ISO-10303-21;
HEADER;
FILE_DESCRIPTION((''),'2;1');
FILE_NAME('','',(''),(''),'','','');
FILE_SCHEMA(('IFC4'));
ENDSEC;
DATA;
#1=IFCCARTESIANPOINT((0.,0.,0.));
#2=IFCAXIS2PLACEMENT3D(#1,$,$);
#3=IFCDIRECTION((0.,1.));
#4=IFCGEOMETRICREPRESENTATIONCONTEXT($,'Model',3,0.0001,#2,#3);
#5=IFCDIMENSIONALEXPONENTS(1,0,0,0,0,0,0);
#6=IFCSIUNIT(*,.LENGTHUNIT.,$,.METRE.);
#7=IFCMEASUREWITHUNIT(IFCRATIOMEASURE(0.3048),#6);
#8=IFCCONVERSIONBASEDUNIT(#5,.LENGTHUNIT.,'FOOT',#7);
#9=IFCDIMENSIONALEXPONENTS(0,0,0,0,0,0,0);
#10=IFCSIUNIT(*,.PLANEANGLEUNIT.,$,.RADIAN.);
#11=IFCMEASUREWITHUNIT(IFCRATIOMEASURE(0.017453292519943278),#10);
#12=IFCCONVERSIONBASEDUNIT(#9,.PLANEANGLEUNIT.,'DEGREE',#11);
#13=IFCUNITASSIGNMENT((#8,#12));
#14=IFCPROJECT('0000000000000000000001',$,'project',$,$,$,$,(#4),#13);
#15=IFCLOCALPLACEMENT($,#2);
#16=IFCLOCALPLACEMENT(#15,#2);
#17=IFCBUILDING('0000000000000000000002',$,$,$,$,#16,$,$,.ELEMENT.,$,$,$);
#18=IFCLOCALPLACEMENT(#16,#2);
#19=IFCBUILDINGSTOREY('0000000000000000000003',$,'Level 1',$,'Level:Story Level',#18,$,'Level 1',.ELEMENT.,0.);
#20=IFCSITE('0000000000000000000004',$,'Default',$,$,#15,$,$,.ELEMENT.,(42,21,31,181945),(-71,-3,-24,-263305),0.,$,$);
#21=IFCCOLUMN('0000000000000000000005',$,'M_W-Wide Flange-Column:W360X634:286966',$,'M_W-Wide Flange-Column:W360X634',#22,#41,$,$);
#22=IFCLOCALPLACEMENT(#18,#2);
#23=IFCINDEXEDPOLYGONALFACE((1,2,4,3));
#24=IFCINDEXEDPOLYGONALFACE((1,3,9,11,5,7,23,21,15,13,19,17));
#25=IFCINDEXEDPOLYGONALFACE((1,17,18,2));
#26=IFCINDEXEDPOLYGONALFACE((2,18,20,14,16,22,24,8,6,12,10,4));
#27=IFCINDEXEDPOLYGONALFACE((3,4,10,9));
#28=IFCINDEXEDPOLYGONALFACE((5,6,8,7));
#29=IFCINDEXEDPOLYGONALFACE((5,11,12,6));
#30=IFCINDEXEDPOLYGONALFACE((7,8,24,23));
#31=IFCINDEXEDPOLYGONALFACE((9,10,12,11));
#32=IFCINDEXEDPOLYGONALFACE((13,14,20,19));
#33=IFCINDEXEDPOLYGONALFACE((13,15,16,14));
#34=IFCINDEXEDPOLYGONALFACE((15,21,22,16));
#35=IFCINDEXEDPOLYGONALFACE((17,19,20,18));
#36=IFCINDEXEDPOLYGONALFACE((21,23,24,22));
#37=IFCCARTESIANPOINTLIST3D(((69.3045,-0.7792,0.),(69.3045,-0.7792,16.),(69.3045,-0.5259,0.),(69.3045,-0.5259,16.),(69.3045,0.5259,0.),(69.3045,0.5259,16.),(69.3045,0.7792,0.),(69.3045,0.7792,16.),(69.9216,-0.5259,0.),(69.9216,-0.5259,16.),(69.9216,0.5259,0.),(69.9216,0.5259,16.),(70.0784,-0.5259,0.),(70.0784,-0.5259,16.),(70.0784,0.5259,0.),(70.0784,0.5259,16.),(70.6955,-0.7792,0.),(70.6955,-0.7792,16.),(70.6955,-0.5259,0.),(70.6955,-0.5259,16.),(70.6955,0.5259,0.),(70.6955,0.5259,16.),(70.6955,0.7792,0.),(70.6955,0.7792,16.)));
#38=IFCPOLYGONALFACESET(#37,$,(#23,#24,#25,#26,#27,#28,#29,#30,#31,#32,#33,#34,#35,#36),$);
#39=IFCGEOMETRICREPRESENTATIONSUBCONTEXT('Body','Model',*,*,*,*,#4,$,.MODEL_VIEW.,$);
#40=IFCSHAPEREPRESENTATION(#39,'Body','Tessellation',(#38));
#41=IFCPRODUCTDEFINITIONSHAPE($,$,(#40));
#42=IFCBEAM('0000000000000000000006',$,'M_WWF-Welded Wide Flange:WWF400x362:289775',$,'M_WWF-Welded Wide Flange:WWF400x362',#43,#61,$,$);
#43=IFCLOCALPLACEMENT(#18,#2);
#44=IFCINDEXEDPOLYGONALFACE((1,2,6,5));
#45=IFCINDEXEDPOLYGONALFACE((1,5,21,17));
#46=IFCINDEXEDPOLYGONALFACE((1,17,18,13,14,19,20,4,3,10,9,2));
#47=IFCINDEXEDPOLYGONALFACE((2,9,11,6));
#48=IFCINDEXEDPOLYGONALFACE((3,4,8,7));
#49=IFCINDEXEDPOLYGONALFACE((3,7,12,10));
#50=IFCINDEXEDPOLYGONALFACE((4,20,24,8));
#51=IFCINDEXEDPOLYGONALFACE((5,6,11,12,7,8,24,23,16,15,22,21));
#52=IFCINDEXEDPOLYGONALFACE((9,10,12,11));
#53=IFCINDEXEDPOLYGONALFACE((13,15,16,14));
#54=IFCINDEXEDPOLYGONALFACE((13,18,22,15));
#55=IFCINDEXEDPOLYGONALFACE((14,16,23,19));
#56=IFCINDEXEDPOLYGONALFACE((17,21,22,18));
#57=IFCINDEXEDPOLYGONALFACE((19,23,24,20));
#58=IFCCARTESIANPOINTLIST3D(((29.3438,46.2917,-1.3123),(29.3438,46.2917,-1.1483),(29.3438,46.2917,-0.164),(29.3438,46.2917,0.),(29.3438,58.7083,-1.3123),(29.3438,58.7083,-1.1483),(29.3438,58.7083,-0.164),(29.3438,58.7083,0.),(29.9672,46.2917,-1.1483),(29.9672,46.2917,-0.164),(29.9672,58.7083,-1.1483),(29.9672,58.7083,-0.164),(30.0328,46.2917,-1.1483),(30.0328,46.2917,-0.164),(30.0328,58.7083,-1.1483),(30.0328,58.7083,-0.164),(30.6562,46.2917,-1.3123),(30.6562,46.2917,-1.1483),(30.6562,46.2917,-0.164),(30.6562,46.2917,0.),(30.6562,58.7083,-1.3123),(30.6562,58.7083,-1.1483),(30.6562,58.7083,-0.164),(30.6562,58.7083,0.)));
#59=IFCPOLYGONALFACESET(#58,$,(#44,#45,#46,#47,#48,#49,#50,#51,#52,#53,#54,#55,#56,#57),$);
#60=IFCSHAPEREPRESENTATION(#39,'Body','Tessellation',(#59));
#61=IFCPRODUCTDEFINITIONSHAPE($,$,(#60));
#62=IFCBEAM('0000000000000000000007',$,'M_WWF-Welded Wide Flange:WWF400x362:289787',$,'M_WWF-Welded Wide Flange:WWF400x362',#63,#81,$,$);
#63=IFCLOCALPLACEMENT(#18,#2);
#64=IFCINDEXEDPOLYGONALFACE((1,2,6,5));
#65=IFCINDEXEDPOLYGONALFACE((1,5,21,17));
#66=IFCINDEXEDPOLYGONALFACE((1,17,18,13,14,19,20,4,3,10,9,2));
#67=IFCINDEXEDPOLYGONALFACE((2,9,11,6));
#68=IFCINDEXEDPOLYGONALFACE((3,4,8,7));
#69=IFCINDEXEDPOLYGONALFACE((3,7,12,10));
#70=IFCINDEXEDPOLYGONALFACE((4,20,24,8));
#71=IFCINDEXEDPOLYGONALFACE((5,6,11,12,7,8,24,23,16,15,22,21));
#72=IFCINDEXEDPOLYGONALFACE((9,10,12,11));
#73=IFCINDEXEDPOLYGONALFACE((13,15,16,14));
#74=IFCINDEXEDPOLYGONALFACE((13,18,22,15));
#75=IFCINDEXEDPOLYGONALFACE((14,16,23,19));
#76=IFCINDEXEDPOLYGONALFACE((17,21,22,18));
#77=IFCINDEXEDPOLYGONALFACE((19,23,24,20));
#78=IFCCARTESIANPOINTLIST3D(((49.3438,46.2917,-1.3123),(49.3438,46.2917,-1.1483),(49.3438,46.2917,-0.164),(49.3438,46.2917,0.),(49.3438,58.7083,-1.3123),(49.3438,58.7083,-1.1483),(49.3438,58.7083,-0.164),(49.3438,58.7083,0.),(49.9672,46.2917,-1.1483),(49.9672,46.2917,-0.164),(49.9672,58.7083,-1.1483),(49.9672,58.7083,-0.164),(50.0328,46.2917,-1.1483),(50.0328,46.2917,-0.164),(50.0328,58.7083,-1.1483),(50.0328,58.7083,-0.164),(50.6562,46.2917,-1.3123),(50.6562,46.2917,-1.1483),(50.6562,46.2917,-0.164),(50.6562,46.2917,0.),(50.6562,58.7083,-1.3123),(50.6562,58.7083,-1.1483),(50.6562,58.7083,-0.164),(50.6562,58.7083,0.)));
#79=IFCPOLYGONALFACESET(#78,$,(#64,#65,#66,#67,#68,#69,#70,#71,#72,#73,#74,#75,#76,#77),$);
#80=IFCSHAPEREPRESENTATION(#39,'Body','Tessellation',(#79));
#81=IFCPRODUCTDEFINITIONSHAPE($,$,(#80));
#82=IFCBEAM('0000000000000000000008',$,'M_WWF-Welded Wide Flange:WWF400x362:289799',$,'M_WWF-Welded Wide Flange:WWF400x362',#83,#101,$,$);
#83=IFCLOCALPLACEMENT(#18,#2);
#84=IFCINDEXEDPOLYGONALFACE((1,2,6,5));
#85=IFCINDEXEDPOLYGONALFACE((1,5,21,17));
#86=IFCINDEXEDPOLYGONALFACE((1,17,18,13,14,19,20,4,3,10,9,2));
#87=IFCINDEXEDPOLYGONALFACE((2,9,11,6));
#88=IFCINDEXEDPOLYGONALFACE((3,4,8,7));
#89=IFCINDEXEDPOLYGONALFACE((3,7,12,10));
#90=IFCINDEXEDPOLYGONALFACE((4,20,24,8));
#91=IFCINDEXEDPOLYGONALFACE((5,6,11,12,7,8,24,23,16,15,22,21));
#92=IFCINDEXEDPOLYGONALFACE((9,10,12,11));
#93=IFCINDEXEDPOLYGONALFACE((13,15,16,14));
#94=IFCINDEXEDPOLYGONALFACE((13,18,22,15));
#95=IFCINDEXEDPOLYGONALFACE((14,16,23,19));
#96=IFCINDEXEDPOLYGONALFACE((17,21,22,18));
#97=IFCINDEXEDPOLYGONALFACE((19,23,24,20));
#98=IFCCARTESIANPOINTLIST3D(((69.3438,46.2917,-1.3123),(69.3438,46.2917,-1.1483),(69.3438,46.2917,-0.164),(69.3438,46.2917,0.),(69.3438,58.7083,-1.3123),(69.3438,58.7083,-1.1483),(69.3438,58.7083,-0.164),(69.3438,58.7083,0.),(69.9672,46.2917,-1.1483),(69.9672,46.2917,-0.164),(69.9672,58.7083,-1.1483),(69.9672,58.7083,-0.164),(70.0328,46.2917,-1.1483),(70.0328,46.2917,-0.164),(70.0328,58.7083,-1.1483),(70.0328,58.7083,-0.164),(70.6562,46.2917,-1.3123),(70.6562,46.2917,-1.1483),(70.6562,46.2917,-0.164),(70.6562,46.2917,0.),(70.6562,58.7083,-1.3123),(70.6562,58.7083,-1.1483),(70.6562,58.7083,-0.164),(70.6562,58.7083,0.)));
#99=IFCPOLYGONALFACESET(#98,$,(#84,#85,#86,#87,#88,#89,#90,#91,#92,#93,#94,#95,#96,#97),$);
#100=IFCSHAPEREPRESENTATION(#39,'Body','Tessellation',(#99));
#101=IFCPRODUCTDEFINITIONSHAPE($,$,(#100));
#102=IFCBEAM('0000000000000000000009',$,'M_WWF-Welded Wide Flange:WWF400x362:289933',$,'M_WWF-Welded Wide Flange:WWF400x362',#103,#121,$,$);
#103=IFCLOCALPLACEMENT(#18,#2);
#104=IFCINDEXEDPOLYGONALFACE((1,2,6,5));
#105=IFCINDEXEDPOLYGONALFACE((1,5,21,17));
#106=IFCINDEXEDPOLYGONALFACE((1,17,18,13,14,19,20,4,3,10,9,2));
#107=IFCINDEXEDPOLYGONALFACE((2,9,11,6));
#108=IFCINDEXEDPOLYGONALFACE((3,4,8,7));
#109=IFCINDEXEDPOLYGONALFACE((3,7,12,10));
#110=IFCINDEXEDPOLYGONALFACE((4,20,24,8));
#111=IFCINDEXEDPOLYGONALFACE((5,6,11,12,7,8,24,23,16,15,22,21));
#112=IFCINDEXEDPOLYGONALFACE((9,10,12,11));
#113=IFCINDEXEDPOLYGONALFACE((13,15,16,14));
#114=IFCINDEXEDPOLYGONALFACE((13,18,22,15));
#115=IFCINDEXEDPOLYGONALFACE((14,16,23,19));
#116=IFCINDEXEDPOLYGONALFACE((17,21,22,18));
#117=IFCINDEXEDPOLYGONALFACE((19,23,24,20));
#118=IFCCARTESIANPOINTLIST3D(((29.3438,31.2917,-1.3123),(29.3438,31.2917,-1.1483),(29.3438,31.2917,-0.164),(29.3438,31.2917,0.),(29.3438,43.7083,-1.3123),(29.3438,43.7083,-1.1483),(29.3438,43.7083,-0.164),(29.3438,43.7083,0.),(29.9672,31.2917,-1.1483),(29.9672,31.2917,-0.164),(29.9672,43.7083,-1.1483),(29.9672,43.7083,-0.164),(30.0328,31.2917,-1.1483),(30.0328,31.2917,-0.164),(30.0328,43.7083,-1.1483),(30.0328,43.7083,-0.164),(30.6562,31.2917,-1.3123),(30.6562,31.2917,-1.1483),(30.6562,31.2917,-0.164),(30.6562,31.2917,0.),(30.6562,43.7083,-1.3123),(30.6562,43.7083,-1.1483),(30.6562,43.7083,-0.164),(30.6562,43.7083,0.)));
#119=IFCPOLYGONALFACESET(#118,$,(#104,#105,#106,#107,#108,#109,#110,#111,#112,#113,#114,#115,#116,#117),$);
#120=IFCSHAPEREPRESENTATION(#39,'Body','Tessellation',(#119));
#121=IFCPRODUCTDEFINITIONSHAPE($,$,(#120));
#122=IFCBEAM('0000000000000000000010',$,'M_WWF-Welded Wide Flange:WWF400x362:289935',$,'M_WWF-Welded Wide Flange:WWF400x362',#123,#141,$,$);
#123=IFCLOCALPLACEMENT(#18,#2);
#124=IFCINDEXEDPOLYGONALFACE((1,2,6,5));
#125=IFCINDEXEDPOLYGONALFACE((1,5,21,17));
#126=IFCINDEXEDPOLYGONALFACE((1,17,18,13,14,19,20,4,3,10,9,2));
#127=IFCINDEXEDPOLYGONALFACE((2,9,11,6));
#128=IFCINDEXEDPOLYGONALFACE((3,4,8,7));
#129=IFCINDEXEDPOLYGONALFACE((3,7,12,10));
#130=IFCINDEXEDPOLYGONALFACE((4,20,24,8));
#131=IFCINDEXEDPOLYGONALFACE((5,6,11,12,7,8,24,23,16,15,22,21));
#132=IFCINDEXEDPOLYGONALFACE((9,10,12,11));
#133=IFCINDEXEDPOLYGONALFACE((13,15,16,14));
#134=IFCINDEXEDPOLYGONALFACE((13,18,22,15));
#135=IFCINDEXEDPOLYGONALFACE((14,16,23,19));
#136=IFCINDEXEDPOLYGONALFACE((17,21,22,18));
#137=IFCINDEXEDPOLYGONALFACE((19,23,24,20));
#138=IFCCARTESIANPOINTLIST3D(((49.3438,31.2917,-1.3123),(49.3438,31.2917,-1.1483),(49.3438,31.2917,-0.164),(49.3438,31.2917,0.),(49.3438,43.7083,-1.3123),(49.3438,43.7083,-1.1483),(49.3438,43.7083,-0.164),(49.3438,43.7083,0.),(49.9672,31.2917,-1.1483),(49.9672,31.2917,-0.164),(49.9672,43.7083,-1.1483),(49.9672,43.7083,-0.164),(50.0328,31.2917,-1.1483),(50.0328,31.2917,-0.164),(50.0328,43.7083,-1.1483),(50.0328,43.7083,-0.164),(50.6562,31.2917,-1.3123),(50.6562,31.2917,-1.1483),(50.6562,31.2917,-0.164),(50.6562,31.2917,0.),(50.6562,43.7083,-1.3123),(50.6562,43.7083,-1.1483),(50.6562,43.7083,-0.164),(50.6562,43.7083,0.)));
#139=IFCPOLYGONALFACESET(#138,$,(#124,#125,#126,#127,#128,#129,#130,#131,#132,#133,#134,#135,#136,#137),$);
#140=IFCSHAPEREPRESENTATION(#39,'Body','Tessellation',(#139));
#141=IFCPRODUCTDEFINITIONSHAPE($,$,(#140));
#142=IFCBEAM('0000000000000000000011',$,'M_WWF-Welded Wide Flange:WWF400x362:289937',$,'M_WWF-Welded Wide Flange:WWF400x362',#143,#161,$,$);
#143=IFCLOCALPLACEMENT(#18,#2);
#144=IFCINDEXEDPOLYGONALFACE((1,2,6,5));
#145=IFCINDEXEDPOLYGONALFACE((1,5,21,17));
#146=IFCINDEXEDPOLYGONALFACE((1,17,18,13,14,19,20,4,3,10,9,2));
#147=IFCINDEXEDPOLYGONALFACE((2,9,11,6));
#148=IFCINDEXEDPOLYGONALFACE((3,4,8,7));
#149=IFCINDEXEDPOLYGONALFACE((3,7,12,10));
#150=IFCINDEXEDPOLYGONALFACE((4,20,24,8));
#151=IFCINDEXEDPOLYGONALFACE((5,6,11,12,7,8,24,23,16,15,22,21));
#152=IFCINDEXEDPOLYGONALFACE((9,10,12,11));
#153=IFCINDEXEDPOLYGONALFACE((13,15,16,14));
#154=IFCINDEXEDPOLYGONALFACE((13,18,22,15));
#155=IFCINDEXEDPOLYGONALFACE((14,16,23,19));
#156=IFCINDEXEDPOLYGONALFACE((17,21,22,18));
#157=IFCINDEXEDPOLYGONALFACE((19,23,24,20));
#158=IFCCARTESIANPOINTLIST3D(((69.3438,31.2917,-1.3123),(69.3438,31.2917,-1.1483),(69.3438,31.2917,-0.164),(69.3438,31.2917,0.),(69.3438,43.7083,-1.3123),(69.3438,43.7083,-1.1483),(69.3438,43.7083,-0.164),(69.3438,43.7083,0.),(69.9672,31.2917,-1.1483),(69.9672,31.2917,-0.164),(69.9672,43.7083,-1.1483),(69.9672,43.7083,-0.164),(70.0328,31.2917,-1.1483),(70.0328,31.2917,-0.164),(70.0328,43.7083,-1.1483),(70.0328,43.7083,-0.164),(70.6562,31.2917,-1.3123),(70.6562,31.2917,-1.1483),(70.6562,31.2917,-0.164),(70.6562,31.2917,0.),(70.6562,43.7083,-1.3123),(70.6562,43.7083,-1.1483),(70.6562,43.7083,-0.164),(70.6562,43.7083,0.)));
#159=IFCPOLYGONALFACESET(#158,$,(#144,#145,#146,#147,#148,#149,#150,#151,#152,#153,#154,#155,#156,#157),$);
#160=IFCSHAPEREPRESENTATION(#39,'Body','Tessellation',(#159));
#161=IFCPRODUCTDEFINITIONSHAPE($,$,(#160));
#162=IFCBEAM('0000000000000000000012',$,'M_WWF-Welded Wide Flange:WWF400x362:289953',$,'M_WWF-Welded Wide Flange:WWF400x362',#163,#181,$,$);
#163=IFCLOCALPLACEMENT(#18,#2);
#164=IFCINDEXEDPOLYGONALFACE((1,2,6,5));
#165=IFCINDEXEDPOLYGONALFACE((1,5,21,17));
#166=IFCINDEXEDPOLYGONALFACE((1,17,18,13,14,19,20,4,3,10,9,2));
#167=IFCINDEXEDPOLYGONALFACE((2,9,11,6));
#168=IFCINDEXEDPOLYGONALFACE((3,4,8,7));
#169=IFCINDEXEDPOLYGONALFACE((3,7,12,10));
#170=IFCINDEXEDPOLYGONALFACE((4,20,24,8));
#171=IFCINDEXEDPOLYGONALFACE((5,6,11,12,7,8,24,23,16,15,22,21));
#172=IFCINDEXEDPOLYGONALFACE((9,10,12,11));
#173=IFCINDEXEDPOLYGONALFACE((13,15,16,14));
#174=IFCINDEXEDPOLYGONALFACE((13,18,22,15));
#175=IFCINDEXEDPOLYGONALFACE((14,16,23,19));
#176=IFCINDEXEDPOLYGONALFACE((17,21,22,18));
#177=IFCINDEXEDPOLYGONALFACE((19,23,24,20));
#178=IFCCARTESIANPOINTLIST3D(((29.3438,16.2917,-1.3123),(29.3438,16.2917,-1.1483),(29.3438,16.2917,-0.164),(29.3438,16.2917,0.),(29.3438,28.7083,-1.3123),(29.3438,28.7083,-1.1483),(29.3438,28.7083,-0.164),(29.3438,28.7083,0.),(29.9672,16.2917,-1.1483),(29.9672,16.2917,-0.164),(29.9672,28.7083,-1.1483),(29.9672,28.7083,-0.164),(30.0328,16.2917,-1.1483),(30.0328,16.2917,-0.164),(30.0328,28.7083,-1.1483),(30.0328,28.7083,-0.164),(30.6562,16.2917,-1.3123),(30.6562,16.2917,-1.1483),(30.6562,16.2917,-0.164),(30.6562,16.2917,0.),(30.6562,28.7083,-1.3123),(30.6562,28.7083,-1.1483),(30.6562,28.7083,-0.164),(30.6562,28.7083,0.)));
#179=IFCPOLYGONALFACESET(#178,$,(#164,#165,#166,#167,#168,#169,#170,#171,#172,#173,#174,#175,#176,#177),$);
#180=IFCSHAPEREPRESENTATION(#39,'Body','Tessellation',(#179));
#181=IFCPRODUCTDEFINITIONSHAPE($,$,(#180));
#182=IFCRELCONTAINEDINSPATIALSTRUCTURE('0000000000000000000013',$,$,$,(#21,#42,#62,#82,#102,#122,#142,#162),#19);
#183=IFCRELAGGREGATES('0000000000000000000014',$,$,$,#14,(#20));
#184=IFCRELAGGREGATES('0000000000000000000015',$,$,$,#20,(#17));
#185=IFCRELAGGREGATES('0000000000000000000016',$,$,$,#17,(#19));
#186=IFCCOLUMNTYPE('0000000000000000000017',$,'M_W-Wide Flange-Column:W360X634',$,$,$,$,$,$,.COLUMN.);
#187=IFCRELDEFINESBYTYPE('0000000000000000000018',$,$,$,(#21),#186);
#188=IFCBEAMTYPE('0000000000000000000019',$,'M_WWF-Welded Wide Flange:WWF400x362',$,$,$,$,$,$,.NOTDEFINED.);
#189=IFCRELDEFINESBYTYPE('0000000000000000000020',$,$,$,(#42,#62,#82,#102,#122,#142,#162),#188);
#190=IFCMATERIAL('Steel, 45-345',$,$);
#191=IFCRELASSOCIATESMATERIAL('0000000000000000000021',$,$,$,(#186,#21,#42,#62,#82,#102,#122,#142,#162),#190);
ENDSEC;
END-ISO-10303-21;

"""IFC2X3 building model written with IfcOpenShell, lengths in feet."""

from ifc_helpers import new_model, entity, si_unit, converted_unit, direction, frame, frame_2d, origin, place, context, subcontext, project, spatial, polyline, i_section, outline, extrude, source, transform, mapped, material, type_object, type_shapes, element, save


model = new_model("IFC2X3")

# Units and contexts
model_context = context("Model", 3, precision=0.0001, world=origin(), true_north=direction((0.0, 1.0)))
body_context = subcontext(model_context, "Body", "Model", "MODEL_VIEW")
ifc_project = project(units=[converted_unit("LENGTHUNIT", "FOOT", entity("IfcRatioMeasure", 0.3048), si_unit("LENGTHUNIT", "METRE"), dimensions=[1, 0, 0, 0, 0, 0, 0]), converted_unit("PLANEANGLEUNIT", "DEGREE", entity("IfcRatioMeasure", 0.017453292519943278), si_unit("PLANEANGLEUNIT", "RADIAN"), dimensions=[0, 0, 0, 0, 0, 0, 0])], contexts=[model_context])

# Site, building, storey
site_placement = place(None, origin())
site = spatial("IfcSite", under=ifc_project, at=site_placement, Name="Default", CompositionType="ELEMENT", RefLatitude=(42, 21, 31, 181945), RefLongitude=(-71, -3, -24, -263305), RefElevation=0.0)
building_placement = place(site_placement, origin())
building = spatial("IfcBuilding", under=site, at=building_placement, CompositionType="ELEMENT")
storey_placement = place(building_placement, origin())
storey = spatial("IfcBuildingStorey", under=building, at=storey_placement, Name="Level 1", ObjectType="Level:Story Level", LongName="Level 1", CompositionType="ELEMENT", Elevation=0.0)

# Column
ifc_material = material(Name="Steel, 45-345")
column_type = type_object("IfcColumnType", Name="M_W-Wide Flange-Column:W360X634", PredefinedType="COLUMN", material=ifc_material)
shared_shape = source(origin(), body_context, "Body", "SweptSolid", [
    extrude(outline(polyline([(0.5259, -0.6955), (0.7792, -0.6955), (0.7792, 0.6955), (0.5259, 0.6955), (0.5259, 0.0784), (-0.5259, 0.0784), (-0.5259, 0.6955), (-0.7792, 0.6955), (-0.7792, -0.6955), (-0.5259, -0.6955), (-0.5259, -0.0784), (0.5259, -0.0784), (0.5259, -0.6955)])), frame((0.0, 0.0, 0.0), z_axis=(0.0, 0.0, 1.0), x_axis=(0.0, -1.0, 0.0)), (0.0, 0.0, 1.0), 16.0),
])
type_shapes(column_type, [shared_shape])
for number, where, name in (
    (1, (70.0, 0.0, 0.0), "M_W-Wide Flange-Column:W360X634:286966"),
):
    element("IfcColumn", number, at=place(storey_placement, frame(where)), inside=storey, type_object=column_type, material=ifc_material, Name=name, ObjectType="M_W-Wide Flange-Column:W360X634", context=body_context, shape_type="MappedRepresentation", body=[
        mapped(shared_shape, transform((0.0, 0.0, 0.0), scale=1.0)),
    ])

# Beams
beam_type = type_object("IfcBeamType", Name="M_WWF-Welded Wide Flange:WWF400x362", PredefinedType="NOTDEFINED")
beam_1_placement = place(storey_placement, frame((30.0, 45.0, 0.0), z_axis=(0.0, 0.0, 1.0), x_axis=(0.0, 1.0, 0.0)))
element("IfcBeam", 2, at=beam_1_placement, inside=storey, type_object=beam_type, material=ifc_material, Name="M_WWF-Welded Wide Flange:WWF400x362:289775", ObjectType="M_WWF-Welded Wide Flange:WWF400x362", context=body_context, shape_type="SweptSolid", body=[
    extrude(i_section(OverallWidth=1.3123, OverallDepth=1.3123, WebThickness=0.0656, FlangeThickness=0.164, at=frame_2d((0.0, 0.0), x_axis=(0.0, 1.0))), frame((1.2917, 0.0, -0.6562), z_axis=(1.0, 0.0, 0.0), x_axis=(0.0, 0.0, -1.0)), (0.0, 0.0, 1.0), 12.4167),
])
beam_2_placement = place(storey_placement, frame((50.0, 45.0, 0.0), z_axis=(0.0, 0.0, 1.0), x_axis=(0.0, 1.0, 0.0)))
element("IfcBeam", 3, at=beam_2_placement, inside=storey, type_object=beam_type, material=ifc_material, Name="M_WWF-Welded Wide Flange:WWF400x362:289787", ObjectType="M_WWF-Welded Wide Flange:WWF400x362", context=body_context, shape_type="SweptSolid", body=[
    extrude(i_section(OverallWidth=1.3123, OverallDepth=1.3123, WebThickness=0.0656, FlangeThickness=0.164, at=frame_2d((0.0, 0.0), x_axis=(0.0, 1.0))), frame((1.2917, 0.0, -0.6562), z_axis=(1.0, 0.0, 0.0), x_axis=(0.0, 0.0, -1.0)), (0.0, 0.0, 1.0), 12.4167),
])
beam_3_placement = place(storey_placement, frame((70.0, 45.0, 0.0), z_axis=(0.0, 0.0, 1.0), x_axis=(0.0, 1.0, 0.0)))
element("IfcBeam", 4, at=beam_3_placement, inside=storey, type_object=beam_type, material=ifc_material, Name="M_WWF-Welded Wide Flange:WWF400x362:289799", ObjectType="M_WWF-Welded Wide Flange:WWF400x362", context=body_context, shape_type="SweptSolid", body=[
    extrude(i_section(OverallWidth=1.3123, OverallDepth=1.3123, WebThickness=0.0656, FlangeThickness=0.164, at=frame_2d((0.0, 0.0), x_axis=(0.0, 1.0))), frame((1.2917, 0.0, -0.6562), z_axis=(1.0, 0.0, 0.0), x_axis=(0.0, 0.0, -1.0)), (0.0, 0.0, 1.0), 12.4167),
])
beam_4_placement = place(storey_placement, frame((30.0, 30.0, 0.0), z_axis=(0.0, 0.0, 1.0), x_axis=(0.0, 1.0, 0.0)))
element("IfcBeam", 5, at=beam_4_placement, inside=storey, type_object=beam_type, material=ifc_material, Name="M_WWF-Welded Wide Flange:WWF400x362:289933", ObjectType="M_WWF-Welded Wide Flange:WWF400x362", context=body_context, shape_type="SweptSolid", body=[
    extrude(i_section(OverallWidth=1.3123, OverallDepth=1.3123, WebThickness=0.0656, FlangeThickness=0.164, at=frame_2d((0.0, 0.0), x_axis=(0.0, 1.0))), frame((1.2917, 0.0, -0.6562), z_axis=(1.0, 0.0, 0.0), x_axis=(0.0, 0.0, -1.0)), (0.0, 0.0, 1.0), 12.4167),
])
beam_5_placement = place(storey_placement, frame((50.0, 30.0, 0.0), z_axis=(0.0, 0.0, 1.0), x_axis=(0.0, 1.0, 0.0)))
element("IfcBeam", 6, at=beam_5_placement, inside=storey, type_object=beam_type, material=ifc_material, Name="M_WWF-Welded Wide Flange:WWF400x362:289935", ObjectType="M_WWF-Welded Wide Flange:WWF400x362", context=body_context, shape_type="SweptSolid", body=[
    extrude(i_section(OverallWidth=1.3123, OverallDepth=1.3123, WebThickness=0.0656, FlangeThickness=0.164, at=frame_2d((0.0, 0.0), x_axis=(0.0, 1.0))), frame((1.2917, 0.0, -0.6562), z_axis=(1.0, 0.0, 0.0), x_axis=(0.0, 0.0, -1.0)), (0.0, 0.0, 1.0), 12.4167),
])
beam_6_placement = place(storey_placement, frame((70.0, 30.0, 0.0), z_axis=(0.0, 0.0, 1.0), x_axis=(0.0, 1.0, 0.0)))
element("IfcBeam", 7, at=beam_6_placement, inside=storey, type_object=beam_type, material=ifc_material, Name="M_WWF-Welded Wide Flange:WWF400x362:289937", ObjectType="M_WWF-Welded Wide Flange:WWF400x362", context=body_context, shape_type="SweptSolid", body=[
    extrude(i_section(OverallWidth=1.3123, OverallDepth=1.3123, WebThickness=0.0656, FlangeThickness=0.164, at=frame_2d((0.0, 0.0), x_axis=(0.0, 1.0))), frame((1.2917, 0.0, -0.6562), z_axis=(1.0, 0.0, 0.0), x_axis=(0.0, 0.0, -1.0)), (0.0, 0.0, 1.0), 12.4167),
])
beam_7_placement = place(storey_placement, frame((30.0, 15.0, 0.0), z_axis=(0.0, 0.0, 1.0), x_axis=(0.0, 1.0, 0.0)))
element("IfcBeam", 8, at=beam_7_placement, inside=storey, type_object=beam_type, material=ifc_material, Name="M_WWF-Welded Wide Flange:WWF400x362:289953", ObjectType="M_WWF-Welded Wide Flange:WWF400x362", context=body_context, shape_type="SweptSolid", body=[
    extrude(i_section(OverallWidth=1.3123, OverallDepth=1.3123, WebThickness=0.0656, FlangeThickness=0.164, at=frame_2d((0.0, 0.0), x_axis=(0.0, 1.0))), frame((1.2917, 0.0, -0.6562), z_axis=(1.0, 0.0, 0.0), x_axis=(0.0, 0.0, -1.0)), (0.0, 0.0, 1.0), 12.4167),
])

save(model, "model.ifc")
